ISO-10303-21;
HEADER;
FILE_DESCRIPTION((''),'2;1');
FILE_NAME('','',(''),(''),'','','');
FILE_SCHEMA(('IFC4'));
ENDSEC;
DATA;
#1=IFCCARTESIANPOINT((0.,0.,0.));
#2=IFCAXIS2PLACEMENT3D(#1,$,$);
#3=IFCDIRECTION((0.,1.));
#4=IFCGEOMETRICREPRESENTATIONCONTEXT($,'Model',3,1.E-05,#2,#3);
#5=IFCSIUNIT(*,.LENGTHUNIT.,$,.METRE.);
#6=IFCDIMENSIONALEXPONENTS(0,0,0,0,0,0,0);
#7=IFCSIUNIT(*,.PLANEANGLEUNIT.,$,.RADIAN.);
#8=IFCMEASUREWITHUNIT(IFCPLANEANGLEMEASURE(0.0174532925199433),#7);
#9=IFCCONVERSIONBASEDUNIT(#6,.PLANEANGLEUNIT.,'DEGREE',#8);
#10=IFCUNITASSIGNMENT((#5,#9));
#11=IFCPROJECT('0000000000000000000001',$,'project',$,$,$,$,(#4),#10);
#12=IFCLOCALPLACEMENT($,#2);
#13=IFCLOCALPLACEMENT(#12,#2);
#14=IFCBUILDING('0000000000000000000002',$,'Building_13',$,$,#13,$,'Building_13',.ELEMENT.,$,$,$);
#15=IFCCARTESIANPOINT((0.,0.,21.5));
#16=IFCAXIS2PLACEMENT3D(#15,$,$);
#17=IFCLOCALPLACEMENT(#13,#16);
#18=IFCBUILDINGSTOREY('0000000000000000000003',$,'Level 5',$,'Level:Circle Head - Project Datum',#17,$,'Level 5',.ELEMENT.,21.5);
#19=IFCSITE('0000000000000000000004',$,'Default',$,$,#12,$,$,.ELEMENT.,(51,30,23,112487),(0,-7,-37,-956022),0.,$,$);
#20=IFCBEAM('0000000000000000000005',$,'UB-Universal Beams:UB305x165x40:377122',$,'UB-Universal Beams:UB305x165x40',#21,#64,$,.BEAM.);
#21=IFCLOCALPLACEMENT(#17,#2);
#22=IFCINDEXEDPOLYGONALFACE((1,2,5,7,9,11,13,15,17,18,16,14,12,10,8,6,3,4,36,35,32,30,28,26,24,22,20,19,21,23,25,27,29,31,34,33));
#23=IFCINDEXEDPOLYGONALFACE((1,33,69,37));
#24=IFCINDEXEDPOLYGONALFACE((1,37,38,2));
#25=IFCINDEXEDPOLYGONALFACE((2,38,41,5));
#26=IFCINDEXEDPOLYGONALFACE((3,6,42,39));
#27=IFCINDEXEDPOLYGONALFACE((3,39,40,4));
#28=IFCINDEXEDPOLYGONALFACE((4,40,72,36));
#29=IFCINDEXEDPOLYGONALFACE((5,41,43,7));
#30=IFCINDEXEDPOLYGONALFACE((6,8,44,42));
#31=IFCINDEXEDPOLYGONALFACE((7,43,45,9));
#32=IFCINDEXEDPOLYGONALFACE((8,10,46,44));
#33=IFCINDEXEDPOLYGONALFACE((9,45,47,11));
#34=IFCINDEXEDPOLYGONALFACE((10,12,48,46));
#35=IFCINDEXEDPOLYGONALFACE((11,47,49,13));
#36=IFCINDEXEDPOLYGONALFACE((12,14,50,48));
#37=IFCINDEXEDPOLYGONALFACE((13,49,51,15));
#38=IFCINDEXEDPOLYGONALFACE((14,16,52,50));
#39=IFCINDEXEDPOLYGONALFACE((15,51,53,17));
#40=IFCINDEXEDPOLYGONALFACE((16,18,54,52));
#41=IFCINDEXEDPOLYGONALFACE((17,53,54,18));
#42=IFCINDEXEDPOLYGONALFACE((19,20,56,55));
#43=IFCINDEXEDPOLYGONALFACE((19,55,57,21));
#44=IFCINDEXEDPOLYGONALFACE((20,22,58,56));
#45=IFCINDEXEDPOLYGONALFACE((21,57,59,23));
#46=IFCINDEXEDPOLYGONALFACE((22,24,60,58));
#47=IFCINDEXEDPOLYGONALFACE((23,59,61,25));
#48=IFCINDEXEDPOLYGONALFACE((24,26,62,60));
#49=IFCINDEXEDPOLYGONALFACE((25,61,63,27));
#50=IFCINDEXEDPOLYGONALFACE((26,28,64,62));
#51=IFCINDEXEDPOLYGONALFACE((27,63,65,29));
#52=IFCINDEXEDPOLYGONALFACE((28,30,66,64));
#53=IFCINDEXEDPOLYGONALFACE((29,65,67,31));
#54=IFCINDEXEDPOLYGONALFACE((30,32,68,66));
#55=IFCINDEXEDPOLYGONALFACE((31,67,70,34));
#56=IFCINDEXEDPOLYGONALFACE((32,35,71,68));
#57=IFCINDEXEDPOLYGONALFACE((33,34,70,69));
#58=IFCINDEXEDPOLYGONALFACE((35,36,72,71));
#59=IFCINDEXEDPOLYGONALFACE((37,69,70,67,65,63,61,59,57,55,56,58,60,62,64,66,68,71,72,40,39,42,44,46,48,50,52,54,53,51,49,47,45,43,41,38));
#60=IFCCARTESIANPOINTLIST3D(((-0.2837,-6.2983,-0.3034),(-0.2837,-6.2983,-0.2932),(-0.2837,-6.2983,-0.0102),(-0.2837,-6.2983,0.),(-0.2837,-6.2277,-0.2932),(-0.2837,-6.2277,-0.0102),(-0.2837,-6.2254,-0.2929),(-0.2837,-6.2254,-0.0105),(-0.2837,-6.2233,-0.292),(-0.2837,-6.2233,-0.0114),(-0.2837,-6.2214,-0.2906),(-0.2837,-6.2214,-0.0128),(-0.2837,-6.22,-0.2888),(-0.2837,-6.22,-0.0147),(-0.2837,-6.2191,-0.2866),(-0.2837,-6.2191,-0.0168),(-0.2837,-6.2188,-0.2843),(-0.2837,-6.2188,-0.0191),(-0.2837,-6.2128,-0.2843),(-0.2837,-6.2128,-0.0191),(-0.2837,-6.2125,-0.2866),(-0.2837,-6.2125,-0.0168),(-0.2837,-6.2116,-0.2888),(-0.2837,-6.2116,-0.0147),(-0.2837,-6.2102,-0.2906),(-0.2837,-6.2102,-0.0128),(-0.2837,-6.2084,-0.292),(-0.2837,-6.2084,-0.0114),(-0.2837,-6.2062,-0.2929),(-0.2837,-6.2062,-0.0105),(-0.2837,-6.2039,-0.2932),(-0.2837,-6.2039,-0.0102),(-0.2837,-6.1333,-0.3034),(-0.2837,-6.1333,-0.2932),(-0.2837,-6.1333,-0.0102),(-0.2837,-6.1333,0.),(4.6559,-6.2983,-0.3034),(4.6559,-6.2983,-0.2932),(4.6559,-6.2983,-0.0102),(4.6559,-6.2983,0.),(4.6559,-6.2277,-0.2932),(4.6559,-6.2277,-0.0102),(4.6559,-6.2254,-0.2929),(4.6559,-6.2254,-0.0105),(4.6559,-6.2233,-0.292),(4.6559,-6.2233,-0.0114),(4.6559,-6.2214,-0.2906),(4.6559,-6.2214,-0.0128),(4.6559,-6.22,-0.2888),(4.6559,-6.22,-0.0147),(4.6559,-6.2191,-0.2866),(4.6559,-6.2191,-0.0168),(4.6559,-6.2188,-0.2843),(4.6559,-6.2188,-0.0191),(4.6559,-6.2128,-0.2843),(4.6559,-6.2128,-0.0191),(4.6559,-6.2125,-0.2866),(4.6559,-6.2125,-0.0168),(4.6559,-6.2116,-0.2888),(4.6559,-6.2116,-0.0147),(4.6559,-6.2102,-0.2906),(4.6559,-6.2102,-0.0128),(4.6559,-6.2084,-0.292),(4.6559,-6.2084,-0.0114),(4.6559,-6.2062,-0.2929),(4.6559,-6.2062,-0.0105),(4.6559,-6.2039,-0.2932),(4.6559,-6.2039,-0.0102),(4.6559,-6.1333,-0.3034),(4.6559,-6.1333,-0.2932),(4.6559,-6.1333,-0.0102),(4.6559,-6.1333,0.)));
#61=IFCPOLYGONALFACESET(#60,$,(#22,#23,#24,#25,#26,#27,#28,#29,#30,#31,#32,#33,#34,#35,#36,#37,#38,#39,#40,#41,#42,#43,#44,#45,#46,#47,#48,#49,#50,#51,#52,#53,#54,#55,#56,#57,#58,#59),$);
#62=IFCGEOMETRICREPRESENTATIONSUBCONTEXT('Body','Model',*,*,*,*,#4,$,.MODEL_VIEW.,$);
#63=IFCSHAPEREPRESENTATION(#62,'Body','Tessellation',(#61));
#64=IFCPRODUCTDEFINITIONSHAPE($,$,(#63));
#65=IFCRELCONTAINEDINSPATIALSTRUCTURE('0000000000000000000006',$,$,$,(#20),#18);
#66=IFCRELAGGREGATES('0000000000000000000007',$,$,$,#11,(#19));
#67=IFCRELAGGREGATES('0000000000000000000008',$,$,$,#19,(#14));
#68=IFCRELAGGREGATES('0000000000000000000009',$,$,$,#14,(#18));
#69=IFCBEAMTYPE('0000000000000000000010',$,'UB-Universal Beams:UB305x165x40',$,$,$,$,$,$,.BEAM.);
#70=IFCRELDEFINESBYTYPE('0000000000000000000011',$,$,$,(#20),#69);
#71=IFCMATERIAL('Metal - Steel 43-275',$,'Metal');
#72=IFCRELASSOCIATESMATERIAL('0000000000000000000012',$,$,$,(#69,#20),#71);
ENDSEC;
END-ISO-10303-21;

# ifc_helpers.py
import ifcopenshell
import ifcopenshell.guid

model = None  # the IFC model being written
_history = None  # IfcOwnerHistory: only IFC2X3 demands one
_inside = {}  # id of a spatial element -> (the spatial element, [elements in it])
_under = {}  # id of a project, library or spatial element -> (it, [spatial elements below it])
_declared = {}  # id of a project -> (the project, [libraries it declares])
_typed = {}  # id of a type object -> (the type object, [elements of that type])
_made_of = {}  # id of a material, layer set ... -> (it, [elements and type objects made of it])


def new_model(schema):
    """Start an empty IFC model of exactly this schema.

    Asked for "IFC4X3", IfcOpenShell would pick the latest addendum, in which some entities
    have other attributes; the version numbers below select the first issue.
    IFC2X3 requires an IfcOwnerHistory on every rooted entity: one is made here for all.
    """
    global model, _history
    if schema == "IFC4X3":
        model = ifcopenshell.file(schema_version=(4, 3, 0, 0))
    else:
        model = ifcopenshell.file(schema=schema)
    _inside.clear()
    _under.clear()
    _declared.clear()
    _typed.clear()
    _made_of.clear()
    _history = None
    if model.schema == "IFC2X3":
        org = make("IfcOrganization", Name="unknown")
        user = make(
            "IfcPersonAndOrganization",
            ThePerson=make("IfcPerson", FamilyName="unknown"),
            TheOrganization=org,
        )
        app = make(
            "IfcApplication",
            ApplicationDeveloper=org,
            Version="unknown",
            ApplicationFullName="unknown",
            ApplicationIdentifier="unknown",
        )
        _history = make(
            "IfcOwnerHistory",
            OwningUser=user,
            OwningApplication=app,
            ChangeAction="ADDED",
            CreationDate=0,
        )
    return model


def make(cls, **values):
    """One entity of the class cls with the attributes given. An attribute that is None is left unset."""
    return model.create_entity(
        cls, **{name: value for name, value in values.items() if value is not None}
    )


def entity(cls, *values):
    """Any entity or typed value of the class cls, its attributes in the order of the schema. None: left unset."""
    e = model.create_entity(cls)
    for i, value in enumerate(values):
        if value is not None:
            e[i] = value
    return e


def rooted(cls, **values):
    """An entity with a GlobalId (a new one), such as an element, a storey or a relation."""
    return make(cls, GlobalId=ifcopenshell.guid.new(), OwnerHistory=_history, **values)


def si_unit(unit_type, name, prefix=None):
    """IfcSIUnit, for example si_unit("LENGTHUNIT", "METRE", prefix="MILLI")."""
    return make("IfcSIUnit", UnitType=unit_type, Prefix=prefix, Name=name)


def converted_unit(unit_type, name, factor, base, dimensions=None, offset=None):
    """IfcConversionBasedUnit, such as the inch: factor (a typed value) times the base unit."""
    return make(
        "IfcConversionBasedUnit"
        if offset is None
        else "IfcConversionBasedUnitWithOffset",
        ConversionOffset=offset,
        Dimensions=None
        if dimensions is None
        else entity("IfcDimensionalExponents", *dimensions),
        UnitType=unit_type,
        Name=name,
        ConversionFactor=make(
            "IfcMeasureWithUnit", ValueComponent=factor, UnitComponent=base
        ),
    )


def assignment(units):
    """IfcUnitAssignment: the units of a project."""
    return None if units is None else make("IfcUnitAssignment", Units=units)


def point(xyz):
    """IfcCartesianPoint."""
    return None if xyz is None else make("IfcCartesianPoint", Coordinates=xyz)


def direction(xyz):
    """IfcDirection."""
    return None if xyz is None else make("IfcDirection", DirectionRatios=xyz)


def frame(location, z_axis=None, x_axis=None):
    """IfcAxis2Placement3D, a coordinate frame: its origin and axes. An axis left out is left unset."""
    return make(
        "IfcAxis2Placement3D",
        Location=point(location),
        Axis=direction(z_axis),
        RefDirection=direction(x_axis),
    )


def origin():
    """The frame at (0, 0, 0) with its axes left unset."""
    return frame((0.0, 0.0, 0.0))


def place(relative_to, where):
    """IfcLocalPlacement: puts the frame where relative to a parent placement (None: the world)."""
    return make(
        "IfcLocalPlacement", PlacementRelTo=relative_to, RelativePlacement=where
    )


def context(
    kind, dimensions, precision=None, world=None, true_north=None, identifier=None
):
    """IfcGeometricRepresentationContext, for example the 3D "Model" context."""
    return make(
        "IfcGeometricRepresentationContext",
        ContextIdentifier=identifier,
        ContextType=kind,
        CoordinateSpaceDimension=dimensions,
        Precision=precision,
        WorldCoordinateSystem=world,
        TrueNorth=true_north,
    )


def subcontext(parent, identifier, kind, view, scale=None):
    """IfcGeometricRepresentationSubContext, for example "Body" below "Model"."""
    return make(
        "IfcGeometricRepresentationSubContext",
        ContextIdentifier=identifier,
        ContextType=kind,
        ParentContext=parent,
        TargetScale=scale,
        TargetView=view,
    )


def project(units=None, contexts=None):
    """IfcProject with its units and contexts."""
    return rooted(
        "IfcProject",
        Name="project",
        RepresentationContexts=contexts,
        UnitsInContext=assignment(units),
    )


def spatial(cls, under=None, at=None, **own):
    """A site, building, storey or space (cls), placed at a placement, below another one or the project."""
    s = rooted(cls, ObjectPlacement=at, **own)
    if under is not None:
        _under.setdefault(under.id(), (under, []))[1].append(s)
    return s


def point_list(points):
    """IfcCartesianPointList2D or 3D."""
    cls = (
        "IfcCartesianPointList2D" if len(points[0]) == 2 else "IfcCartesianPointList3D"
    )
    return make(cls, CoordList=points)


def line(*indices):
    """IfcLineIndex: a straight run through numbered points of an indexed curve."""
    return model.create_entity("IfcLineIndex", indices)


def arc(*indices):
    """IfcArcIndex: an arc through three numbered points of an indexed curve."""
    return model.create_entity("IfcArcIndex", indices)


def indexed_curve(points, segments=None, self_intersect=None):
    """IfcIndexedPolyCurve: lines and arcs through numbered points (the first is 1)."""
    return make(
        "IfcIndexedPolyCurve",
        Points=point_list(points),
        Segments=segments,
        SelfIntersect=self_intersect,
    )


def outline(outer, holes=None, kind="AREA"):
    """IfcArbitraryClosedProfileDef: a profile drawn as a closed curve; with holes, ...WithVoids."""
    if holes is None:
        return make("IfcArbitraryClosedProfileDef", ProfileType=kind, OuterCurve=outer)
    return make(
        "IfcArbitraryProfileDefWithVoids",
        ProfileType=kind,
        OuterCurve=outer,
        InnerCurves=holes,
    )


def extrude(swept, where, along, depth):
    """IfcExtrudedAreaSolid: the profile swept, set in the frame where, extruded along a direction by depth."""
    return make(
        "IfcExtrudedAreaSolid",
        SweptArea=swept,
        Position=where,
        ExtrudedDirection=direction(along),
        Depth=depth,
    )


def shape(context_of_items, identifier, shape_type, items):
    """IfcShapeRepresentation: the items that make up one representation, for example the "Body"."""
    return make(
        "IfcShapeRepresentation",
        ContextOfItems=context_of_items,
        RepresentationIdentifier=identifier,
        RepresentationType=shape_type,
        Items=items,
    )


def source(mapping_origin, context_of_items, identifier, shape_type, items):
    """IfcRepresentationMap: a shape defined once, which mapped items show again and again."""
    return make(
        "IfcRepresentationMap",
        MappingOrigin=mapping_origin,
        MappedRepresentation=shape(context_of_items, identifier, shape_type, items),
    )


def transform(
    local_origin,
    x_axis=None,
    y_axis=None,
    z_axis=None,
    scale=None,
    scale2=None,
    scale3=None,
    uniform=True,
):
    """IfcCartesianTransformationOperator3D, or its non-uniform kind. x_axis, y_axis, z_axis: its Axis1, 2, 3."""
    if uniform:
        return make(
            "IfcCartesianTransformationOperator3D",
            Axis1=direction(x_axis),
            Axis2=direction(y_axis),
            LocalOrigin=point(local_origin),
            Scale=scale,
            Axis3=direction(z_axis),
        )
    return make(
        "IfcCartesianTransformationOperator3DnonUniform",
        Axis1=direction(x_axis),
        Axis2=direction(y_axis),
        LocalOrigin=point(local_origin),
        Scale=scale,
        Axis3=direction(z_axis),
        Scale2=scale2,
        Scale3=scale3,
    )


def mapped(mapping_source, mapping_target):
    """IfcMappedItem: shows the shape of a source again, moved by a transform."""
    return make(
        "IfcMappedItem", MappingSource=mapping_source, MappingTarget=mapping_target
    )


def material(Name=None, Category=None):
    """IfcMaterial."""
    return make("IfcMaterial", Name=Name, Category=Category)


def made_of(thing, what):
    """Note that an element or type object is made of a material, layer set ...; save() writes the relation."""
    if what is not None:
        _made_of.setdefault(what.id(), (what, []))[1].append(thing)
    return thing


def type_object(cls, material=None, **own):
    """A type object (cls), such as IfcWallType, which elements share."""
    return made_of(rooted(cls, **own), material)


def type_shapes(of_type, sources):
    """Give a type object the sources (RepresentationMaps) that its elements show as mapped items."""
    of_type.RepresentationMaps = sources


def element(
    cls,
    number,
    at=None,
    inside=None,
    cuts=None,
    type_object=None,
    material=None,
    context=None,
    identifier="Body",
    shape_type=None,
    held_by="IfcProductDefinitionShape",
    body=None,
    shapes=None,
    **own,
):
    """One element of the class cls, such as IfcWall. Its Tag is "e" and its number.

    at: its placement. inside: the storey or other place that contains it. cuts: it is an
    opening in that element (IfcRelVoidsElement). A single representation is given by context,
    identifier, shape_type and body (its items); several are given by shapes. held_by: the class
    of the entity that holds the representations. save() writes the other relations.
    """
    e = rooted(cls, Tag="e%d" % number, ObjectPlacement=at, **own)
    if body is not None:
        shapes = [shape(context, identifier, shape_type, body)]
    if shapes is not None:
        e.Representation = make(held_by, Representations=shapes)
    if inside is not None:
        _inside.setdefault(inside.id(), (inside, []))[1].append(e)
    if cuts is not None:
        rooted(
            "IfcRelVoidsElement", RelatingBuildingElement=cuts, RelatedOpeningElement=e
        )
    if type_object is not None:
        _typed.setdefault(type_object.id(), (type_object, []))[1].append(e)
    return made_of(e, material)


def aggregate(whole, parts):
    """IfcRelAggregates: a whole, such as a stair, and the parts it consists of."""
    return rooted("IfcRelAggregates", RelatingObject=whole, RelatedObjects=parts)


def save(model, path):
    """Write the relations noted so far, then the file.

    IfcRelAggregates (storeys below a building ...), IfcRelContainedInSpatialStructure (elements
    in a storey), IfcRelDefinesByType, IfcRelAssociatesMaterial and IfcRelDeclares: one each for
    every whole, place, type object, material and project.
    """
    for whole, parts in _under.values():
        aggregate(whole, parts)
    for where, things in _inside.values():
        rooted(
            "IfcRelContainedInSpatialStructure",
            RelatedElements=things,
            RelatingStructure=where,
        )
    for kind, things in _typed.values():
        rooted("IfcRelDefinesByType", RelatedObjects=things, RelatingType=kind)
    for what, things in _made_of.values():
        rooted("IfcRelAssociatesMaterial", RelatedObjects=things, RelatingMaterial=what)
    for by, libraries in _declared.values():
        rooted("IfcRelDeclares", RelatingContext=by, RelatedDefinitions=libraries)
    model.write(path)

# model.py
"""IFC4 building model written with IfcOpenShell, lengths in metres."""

from ifc_helpers import new_model, entity, si_unit, converted_unit, direction, frame, origin, place, context, subcontext, project, spatial, line, arc, indexed_curve, outline, extrude, source, transform, mapped, material, type_object, type_shapes, element, save


model = new_model("IFC4")

# Units and contexts
model_context = context("Model", 3, precision=1e-05, world=origin(), true_north=direction((0.0, 1.0)))
body_context = subcontext(model_context, "Body", "Model", "MODEL_VIEW")
ifc_project = project(units=[si_unit("LENGTHUNIT", "METRE"), converted_unit("PLANEANGLEUNIT", "DEGREE", entity("IfcPlaneAngleMeasure", 0.0174532925199433), si_unit("PLANEANGLEUNIT", "RADIAN"), dimensions=[0, 0, 0, 0, 0, 0, 0])], contexts=[model_context])

# Site, building, storey
site_placement = place(None, origin())
site = spatial("IfcSite", under=ifc_project, at=site_placement, Name="Default", CompositionType="ELEMENT", RefLatitude=(51, 30, 23, 112487), RefLongitude=(0, -7, -37, -956022), RefElevation=0.0)
building_placement = place(site_placement, origin())
building = spatial("IfcBuilding", under=site, at=building_placement, Name="Building_13", LongName="Building_13", CompositionType="ELEMENT")
storey_placement = place(building_placement, frame((0.0, 0.0, 21.5)))
storey = spatial("IfcBuildingStorey", under=building, at=storey_placement, Name="Level 5", ObjectType="Level:Circle Head - Project Datum", LongName="Level 5", CompositionType="ELEMENT", Elevation=21.5)

# Beam
ifc_material = material(Name="Metal - Steel 43-275", Category="Metal")
beam_type_1 = type_object("IfcBeamType", Name="UB-Universal Beams:UB305x165x40", PredefinedType="BEAM", material=ifc_material)
shared_shape_1 = source(origin(), body_context, "Body", "SweptSolid", [
    extrude(outline(indexed_curve([(-0.0825, -0.1415), (-0.0825, -0.1517), (0.0825, -0.1517), (0.0825, -0.1415), (0.0119, -0.1415), (0.0056, -0.1389), (0.003, -0.1326), (0.003, 0.1326), (0.0056, 0.1389), (0.0119, 0.1415), (0.0825, 0.1415), (0.0825, 0.1517), (-0.0825, 0.1517), (-0.0825, 0.1415), (-0.0119, 0.1415), (-0.0056, 0.1389), (-0.003, 0.1326), (-0.003, -0.1326), (-0.0056, -0.1389), (-0.0119, -0.1415)], segments=[line(1, 2, 3, 4, 5), arc(5, 6, 7), line(7, 8), arc(8, 9, 10), line(10, 11, 12, 13, 14, 15), arc(15, 16, 17), line(17, 18), arc(18, 19, 20), line(20, 1)], self_intersect=False)), frame((-2.3846, 0.0, 0.0), z_axis=(-1.0, 0.0, 0.0), x_axis=(0.0, -1.0, 0.0)), (0.0, 0.0, -1.0), 4.9396),
])
type_shapes(beam_type_1, [shared_shape_1])
beam_1_placement = place(storey_placement, frame((2.1009, -6.2158, -0.1517)))
element("IfcBeam", 1, at=beam_1_placement, inside=storey, type_object=beam_type_1, material=ifc_material, Name="UB-Universal Beams:UB305x165x40:377122", ObjectType="UB-Universal Beams:UB305x165x40", PredefinedType="BEAM", context=body_context, shape_type="MappedRepresentation", body=[
    mapped(shared_shape_1, transform((0.0, 0.0, 0.0), scale=1.0)),
])

save(model, "model.ifc")
